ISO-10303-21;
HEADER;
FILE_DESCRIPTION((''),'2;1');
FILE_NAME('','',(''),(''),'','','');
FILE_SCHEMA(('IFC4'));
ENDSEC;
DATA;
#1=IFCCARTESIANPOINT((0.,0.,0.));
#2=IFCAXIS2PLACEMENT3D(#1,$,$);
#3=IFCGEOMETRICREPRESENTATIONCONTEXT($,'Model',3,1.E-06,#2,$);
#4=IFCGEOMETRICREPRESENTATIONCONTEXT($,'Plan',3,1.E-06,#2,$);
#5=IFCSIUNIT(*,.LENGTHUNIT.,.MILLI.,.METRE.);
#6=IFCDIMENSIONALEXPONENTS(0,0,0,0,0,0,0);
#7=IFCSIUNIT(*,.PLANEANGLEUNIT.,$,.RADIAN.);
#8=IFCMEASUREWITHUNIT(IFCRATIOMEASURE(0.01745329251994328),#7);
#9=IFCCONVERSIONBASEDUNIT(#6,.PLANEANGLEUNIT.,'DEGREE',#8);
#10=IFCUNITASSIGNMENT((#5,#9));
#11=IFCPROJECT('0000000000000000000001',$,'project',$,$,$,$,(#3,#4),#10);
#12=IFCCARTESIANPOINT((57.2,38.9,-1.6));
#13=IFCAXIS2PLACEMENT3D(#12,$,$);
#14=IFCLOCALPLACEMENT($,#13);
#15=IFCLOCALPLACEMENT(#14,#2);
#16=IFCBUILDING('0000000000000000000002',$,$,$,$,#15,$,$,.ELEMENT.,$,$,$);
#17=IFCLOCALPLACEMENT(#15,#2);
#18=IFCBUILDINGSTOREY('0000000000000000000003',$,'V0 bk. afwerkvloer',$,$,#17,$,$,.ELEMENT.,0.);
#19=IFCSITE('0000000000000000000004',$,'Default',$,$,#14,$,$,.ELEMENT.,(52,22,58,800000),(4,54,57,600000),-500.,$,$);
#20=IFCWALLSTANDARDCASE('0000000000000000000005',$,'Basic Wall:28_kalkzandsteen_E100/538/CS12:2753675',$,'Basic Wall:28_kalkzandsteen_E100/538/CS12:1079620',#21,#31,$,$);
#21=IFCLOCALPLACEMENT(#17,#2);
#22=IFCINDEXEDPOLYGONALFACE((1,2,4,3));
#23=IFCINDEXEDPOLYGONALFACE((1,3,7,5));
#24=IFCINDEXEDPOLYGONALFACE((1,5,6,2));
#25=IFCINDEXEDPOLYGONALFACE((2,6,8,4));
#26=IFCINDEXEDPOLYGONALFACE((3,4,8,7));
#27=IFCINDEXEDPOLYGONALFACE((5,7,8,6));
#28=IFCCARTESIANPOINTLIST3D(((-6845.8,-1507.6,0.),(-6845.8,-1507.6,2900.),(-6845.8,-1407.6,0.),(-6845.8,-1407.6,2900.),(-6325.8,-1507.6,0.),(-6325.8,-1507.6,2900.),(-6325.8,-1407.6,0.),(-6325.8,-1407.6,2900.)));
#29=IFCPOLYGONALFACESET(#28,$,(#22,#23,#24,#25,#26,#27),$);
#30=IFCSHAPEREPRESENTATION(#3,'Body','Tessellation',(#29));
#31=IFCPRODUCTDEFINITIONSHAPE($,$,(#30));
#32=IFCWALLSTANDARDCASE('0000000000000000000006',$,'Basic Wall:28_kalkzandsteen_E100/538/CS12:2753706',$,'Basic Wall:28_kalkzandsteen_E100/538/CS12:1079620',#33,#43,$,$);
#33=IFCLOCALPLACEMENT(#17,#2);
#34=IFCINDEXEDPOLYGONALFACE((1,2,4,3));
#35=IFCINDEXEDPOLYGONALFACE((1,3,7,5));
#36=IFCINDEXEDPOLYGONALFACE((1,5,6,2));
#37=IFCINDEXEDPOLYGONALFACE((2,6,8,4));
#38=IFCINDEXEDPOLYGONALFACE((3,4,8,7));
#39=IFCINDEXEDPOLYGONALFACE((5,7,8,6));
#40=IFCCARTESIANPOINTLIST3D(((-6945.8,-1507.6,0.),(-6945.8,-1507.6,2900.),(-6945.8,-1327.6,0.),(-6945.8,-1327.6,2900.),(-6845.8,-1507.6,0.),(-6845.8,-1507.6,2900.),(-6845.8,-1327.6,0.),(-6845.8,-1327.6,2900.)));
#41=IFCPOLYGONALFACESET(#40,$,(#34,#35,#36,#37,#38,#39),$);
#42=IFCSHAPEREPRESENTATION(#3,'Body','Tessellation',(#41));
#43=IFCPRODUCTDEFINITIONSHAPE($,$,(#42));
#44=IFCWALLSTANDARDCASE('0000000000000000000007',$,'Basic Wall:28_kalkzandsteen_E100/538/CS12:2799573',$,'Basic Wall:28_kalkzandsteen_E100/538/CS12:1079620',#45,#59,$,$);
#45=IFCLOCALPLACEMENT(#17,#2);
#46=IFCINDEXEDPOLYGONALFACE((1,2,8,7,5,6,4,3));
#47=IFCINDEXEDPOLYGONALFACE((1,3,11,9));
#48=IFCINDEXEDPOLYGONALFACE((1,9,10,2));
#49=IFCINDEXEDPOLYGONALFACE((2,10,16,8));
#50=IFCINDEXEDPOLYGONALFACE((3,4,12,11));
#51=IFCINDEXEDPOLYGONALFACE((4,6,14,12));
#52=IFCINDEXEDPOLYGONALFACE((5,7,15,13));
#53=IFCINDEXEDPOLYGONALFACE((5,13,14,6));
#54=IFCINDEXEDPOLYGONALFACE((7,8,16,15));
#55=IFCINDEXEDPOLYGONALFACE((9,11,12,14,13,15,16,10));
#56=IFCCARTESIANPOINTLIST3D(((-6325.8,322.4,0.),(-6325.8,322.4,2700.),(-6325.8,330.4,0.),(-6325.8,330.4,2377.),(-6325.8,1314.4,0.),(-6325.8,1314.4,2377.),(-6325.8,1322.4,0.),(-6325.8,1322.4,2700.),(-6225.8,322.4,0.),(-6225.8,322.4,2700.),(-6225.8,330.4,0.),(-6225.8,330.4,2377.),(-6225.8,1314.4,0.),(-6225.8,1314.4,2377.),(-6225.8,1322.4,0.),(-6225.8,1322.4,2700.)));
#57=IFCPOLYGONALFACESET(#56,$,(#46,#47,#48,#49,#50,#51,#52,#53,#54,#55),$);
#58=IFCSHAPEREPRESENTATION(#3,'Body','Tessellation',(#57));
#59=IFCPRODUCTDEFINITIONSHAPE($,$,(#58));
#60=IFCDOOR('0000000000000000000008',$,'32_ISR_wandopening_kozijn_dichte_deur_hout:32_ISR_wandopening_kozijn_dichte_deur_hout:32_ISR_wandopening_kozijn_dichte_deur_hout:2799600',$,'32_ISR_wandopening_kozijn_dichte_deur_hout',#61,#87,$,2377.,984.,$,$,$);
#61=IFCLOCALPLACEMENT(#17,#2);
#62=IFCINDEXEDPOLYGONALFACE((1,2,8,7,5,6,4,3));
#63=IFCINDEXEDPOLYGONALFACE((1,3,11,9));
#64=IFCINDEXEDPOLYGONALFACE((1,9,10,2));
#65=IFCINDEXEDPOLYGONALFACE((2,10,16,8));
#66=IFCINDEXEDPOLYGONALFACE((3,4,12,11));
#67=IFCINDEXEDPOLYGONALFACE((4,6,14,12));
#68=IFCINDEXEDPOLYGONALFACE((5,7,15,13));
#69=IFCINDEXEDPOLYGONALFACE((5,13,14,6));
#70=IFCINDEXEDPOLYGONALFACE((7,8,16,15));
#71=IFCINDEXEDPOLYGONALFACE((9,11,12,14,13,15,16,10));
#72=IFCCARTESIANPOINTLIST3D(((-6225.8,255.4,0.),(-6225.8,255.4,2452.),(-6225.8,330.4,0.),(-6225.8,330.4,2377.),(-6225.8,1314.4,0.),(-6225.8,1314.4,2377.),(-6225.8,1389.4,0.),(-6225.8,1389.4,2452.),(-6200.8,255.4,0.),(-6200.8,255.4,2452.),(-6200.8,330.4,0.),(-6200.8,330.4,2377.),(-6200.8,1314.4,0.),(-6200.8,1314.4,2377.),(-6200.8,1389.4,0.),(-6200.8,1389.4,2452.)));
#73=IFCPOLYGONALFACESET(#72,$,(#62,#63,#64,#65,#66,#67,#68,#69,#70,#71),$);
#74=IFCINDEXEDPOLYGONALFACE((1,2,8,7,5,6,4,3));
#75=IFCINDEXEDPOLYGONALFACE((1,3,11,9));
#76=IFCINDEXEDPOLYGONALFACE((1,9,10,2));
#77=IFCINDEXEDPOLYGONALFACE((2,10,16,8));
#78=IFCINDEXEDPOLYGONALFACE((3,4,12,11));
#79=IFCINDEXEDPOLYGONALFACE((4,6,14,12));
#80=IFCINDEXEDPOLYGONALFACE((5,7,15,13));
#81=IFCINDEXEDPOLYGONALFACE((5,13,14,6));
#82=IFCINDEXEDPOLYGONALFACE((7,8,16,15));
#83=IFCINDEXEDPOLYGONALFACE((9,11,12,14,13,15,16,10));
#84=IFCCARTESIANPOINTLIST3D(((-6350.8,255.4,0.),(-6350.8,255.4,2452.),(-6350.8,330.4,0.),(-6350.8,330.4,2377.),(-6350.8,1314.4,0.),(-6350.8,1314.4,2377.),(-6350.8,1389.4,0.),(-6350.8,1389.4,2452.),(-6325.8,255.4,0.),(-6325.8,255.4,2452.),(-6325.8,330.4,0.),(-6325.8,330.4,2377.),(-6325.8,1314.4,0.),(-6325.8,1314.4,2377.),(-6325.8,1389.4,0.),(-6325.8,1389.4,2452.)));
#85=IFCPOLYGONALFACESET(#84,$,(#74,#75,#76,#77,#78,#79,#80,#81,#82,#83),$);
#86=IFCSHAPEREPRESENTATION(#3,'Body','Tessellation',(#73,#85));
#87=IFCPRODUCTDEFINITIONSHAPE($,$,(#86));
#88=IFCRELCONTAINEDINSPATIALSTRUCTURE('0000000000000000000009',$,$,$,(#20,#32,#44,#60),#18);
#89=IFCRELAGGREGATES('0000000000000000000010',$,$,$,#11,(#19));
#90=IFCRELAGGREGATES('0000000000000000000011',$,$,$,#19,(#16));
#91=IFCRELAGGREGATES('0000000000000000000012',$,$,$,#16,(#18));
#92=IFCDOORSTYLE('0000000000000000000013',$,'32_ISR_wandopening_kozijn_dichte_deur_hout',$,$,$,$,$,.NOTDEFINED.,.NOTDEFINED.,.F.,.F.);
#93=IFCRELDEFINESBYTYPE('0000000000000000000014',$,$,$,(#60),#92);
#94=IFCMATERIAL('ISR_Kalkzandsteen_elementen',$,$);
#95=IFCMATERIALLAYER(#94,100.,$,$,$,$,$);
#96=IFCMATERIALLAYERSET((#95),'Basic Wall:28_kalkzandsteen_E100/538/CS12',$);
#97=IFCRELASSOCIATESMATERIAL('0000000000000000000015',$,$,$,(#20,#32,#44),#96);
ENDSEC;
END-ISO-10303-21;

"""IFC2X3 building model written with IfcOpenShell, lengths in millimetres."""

from ifc_helpers import new_model, entity, si_unit, converted_unit, frame, frame_2d, origin, place, context, project, spatial, polyline, rectangle, outline, extrude, source, transform, mapped, material, layer, layer_set, layer_usage, type_object, type_shapes, element, fill, save


model = new_model("IFC2X3")

# Units and contexts
model_context = context("Model", 3, precision=1e-06, world=origin())
plan_context = context("Plan", 3, precision=1e-06, world=origin())
ifc_project = project(units=[si_unit("LENGTHUNIT", "METRE", prefix="MILLI"), converted_unit("PLANEANGLEUNIT", "DEGREE", entity("IfcRatioMeasure", 0.01745329251994328), si_unit("PLANEANGLEUNIT", "RADIAN"), dimensions=[0, 0, 0, 0, 0, 0, 0])], contexts=[model_context, plan_context])

# Site, building, storey
site_placement = place(None, frame((57.2, 38.9, -1.6)))
site = spatial("IfcSite", under=ifc_project, at=site_placement, Name="Default", CompositionType="ELEMENT", RefLatitude=(52, 22, 58, 800000), RefLongitude=(4, 54, 57, 600000), RefElevation=-500.0)
building_placement = place(site_placement, origin())
building = spatial("IfcBuilding", under=site, at=building_placement, CompositionType="ELEMENT")
storey_placement = place(building_placement, origin())
storey = spatial("IfcBuildingStorey", under=building, at=storey_placement, Name="V0 bk. afwerkvloer", CompositionType="ELEMENT", Elevation=0.0)

# Shared definitions
ifc_material_1 = material(Name="ISR_Kalkzandsteen_elementen")
ifc_layer_1 = layer(ifc_material_1, 100.0)
ifc_layer_set_1 = layer_set([ifc_layer_1], Name="Basic Wall:28_kalkzandsteen_E100/538/CS12")

# Walls
ifc_layer_usage_1 = layer_usage(ifc_layer_set_1, "AXIS2", "NEGATIVE", 50.0)
wall_1_placement = place(storey_placement, frame((-6325.8, -1457.6, 0.0), z_axis=(0.0, 0.0, 1.0), x_axis=(-1.0, 0.0, 0.0)))
element("IfcWallStandardCase", 1, at=wall_1_placement, inside=storey, material=ifc_layer_usage_1, Name="Basic Wall:28_kalkzandsteen_E100/538/CS12:2753675", ObjectType="Basic Wall:28_kalkzandsteen_E100/538/CS12:1079620", context=model_context, shape_type="SweptSolid", body=[
    extrude(rectangle(XDim=520.0, YDim=100.0, at=frame_2d((260.0, 0.0), x_axis=(-1.0, 0.0))), origin(), (0.0, 0.0, 1.0), 2900.0),
])
ifc_layer_usage_2 = layer_usage(ifc_layer_set_1, "AXIS2", "NEGATIVE", 50.0)
wall_2_placement = place(storey_placement, frame((-6895.8, -1507.6, 0.0), z_axis=(0.0, 0.0, 1.0), x_axis=(0.0, 1.0, 0.0)))
element("IfcWallStandardCase", 2, at=wall_2_placement, inside=storey, material=ifc_layer_usage_2, Name="Basic Wall:28_kalkzandsteen_E100/538/CS12:2753706", ObjectType="Basic Wall:28_kalkzandsteen_E100/538/CS12:1079620", context=model_context, shape_type="SweptSolid", body=[
    extrude(rectangle(XDim=180.0, YDim=100.0, at=frame_2d((90.0, 0.0), x_axis=(-1.0, 0.0))), origin(), (0.0, 0.0, 1.0), 2900.0),
])

# Wall, opening, door
ifc_layer_usage_3 = layer_usage(ifc_layer_set_1, "AXIS2", "NEGATIVE", 50.0)
wall_3_placement = place(storey_placement, frame((-6275.8, 322.4, 0.0), z_axis=(0.0, 0.0, 1.0), x_axis=(0.0, 1.0, 0.0)))
wall_3 = element("IfcWallStandardCase", 3, at=wall_3_placement, inside=storey, material=ifc_layer_usage_3, Name="Basic Wall:28_kalkzandsteen_E100/538/CS12:2799573", ObjectType="Basic Wall:28_kalkzandsteen_E100/538/CS12:1079620", context=model_context, shape_type="SweptSolid", body=[
    extrude(rectangle(XDim=1000.0, YDim=100.0, at=frame_2d((500.0, 0.0), x_axis=(-1.0, 0.0))), origin(), (0.0, 0.0, 1.0), 2700.0),
])
opening_1_placement = place(wall_3_placement, frame((992.0, 50.0, 0.0)))
opening_1 = element("IfcOpeningElement", 4, at=opening_1_placement, cuts=wall_3, ObjectType="Opening", context=model_context, shape_type="SweptSolid", body=[
    extrude(rectangle(XDim=2377.0, YDim=984.0, at=frame_2d((1188.5, 492.0), x_axis=(1.0, 0.0))), frame((0.0, 0.0, 0.0), z_axis=(0.0, -1.0, 0.0), x_axis=(0.0, 0.0, 1.0)), (0.0, 0.0, 1.0), 100.0),
])
door_style_1 = type_object("IfcDoorStyle", Name="32_ISR_wandopening_kozijn_dichte_deur_hout", ConstructionType="NOTDEFINED", OperationType="NOTDEFINED", ParameterTakesPrecedence=False, Sizeable=False)
shared_shape_1 = source(origin(), model_context, "Body", "SweptSolid", [
    extrude(outline(polyline([(-1169.7, 492.0), (1207.2, 492.0), (1207.2, 567.0), (-1244.7, 567.0), (-1244.7, -567.0), (1207.2, -567.0), (1207.2, -492.0), (-1169.7, -492.0), (-1169.7, 492.0)])), frame((492.0, 100.0, 1207.2), z_axis=(0.0, 1.0, 0.0), x_axis=(0.0, 0.0, -1.0)), (0.0, 0.0, 1.0), 25.0),
    extrude(outline(polyline([(-567.0, -1244.7), (567.0, -1244.7), (567.0, 1207.2), (492.0, 1207.2), (492.0, -1169.7), (-492.0, -1169.7), (-492.0, 1207.2), (-567.0, 1207.2), (-567.0, -1244.7)])), frame((492.0, -25.0, 1207.2), z_axis=(0.0, 1.0, 0.0), x_axis=(1.0, 0.0, 0.0)), (0.0, 0.0, 1.0), 25.0),
])
type_shapes(door_style_1, [shared_shape_1])
door_1_placement = place(opening_1_placement, frame((0.0, 0.0, 0.0), z_axis=(0.0, 0.0, 1.0), x_axis=(-1.0, 0.0, 0.0)))
door_1 = element("IfcDoor", 5, at=door_1_placement, inside=storey, type_object=door_style_1, Name="32_ISR_wandopening_kozijn_dichte_deur_hout:32_ISR_wandopening_kozijn_dichte_deur_hout:32_ISR_wandopening_kozijn_dichte_deur_hout:2799600", ObjectType="32_ISR_wandopening_kozijn_dichte_deur_hout", OverallHeight=2377.0, OverallWidth=984.0, context=model_context, shape_type="MappedRepresentation", body=[
    mapped(shared_shape_1, transform((0.0, 0.0, 0.0), scale=1.0)),
])
fill(opening_1, door_1)

save(model, "model.ifc")
